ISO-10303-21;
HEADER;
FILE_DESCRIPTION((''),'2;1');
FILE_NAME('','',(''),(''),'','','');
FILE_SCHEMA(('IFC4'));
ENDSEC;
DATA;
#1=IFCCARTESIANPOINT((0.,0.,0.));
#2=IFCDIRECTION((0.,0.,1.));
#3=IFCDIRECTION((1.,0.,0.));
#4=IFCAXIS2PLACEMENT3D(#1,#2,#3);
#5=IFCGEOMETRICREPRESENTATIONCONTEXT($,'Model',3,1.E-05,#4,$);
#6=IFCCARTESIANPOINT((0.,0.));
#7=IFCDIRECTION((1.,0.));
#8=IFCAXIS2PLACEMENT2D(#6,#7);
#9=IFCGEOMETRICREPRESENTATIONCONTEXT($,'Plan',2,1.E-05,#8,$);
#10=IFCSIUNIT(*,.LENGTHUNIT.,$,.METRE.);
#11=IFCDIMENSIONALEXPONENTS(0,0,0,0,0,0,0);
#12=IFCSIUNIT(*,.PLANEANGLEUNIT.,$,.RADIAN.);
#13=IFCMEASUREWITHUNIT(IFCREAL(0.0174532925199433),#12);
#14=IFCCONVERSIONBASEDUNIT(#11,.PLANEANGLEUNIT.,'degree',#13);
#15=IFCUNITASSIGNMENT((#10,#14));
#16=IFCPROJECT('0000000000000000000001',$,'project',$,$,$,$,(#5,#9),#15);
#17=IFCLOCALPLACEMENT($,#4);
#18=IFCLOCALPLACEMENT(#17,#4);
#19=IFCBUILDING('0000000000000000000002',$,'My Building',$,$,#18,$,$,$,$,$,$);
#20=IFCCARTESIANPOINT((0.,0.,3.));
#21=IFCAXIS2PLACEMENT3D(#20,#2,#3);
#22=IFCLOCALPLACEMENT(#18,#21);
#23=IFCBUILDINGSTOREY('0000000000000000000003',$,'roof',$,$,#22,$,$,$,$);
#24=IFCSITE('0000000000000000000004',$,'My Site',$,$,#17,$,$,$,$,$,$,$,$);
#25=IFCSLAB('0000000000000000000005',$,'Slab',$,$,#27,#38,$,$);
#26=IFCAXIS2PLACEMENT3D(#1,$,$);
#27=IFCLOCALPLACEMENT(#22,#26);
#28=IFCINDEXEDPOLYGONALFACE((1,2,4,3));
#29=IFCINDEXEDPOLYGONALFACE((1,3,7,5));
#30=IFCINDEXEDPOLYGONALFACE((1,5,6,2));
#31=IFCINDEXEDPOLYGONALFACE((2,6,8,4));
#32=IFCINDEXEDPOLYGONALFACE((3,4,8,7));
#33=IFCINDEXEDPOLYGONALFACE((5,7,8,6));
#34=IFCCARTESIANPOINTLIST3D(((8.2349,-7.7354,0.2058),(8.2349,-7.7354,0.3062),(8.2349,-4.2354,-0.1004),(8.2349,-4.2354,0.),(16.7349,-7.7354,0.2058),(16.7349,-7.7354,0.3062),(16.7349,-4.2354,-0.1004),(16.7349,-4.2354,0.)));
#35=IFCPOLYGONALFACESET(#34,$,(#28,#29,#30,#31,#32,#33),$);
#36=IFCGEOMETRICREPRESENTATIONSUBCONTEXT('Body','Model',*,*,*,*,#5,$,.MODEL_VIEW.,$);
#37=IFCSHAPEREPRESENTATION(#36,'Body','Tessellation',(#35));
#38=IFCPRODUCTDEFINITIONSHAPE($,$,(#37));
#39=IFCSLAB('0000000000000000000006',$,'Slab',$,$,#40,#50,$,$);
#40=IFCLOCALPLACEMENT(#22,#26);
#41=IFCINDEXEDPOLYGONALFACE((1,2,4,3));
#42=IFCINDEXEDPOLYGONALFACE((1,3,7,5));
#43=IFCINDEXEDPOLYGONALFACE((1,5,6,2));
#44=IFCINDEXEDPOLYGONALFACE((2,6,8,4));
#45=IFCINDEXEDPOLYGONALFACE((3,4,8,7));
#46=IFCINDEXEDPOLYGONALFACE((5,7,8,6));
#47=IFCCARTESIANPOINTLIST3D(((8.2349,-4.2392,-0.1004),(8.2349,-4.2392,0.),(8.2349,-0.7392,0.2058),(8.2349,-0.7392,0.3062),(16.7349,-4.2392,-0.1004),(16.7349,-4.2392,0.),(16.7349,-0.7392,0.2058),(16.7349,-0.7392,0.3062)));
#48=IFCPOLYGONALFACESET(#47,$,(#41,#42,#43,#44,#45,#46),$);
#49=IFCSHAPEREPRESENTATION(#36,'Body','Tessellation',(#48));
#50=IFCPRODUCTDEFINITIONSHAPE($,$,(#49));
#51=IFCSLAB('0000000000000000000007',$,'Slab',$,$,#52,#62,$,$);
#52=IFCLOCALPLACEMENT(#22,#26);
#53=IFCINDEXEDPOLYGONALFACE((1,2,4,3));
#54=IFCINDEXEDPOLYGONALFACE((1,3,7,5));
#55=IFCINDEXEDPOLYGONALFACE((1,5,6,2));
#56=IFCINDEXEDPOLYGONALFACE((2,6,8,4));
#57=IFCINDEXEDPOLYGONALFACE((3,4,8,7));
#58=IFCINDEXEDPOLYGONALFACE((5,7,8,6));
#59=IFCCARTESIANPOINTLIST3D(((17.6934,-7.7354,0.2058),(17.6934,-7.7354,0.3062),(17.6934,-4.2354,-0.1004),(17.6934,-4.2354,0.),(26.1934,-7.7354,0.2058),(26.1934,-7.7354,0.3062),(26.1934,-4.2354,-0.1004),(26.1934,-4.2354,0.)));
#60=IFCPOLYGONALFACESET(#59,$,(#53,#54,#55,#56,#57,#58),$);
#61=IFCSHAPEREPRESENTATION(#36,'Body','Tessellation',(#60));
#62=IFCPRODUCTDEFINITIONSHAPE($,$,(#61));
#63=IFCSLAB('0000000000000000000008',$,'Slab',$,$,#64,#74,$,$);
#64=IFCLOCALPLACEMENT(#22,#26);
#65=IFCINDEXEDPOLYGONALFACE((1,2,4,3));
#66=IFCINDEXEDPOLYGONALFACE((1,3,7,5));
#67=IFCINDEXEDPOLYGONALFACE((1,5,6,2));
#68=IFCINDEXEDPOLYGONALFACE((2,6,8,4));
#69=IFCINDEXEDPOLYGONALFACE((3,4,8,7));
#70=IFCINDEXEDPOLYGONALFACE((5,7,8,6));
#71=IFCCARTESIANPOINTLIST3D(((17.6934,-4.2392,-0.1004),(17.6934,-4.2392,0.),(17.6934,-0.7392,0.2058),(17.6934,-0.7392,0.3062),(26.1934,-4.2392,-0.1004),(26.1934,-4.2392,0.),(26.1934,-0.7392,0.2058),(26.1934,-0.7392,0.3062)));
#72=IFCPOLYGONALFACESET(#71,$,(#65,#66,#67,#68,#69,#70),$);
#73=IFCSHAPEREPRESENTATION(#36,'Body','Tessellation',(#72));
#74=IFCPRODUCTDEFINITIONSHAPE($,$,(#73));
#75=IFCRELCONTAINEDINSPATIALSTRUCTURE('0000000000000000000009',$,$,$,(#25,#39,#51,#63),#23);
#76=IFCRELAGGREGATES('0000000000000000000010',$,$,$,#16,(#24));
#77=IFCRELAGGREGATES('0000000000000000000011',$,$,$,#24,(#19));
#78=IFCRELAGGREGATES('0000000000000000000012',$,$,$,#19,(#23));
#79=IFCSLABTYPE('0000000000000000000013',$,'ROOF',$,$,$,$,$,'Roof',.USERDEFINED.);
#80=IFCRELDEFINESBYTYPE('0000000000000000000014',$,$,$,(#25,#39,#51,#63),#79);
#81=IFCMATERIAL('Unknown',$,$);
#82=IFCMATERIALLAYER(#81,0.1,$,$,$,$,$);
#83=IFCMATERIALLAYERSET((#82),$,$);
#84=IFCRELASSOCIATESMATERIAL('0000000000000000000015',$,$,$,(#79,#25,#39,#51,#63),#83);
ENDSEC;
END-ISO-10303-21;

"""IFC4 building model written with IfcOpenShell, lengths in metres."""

from ifc_helpers import new_model, entity, si_unit, converted_unit, frame, origin_with_axes, origin_2d_with_axis, place, context, subcontext, project, spatial, indexed_curve, outline, extrude, material, layer, layer_set, layer_usage, type_object, element, save


model = new_model("IFC4")

# Units and contexts
model_context = context("Model", 3, precision=1e-05, world=origin_with_axes())
plan_context = context("Plan", 2, precision=1e-05, world=origin_2d_with_axis())
body_context = subcontext(model_context, "Body", "Model", "MODEL_VIEW")
ifc_project = project(units=[si_unit("LENGTHUNIT", "METRE"), converted_unit("PLANEANGLEUNIT", "degree", entity("IfcReal", 0.0174532925199433), si_unit("PLANEANGLEUNIT", "RADIAN"), dimensions=[0, 0, 0, 0, 0, 0, 0])], contexts=[model_context, plan_context])

# Site, building, storey
site_placement = place(None, origin_with_axes())
site = spatial("IfcSite", under=ifc_project, at=site_placement, Name="My Site")
building_placement = place(site_placement, origin_with_axes())
building = spatial("IfcBuilding", under=site, at=building_placement, Name="My Building")
storey_placement = place(building_placement, frame((0.0, 0.0, 3.0), z_axis=(0.0, 0.0, 1.0), x_axis=(1.0, 0.0, 0.0)))
storey = spatial("IfcBuildingStorey", under=building, at=storey_placement, Name="roof")

# Slabs
ifc_material = material(Name="Unknown")
ifc_layer = layer(ifc_material, 0.1)
ifc_layer_set = layer_set([ifc_layer])
ifc_layer_usage_1 = layer_usage(ifc_layer_set, "AXIS3", "POSITIVE", -0.1)
slab_type = type_object("IfcSlabType", Name="ROOF", ElementType="Roof", PredefinedType="USERDEFINED", material=ifc_layer_set)
slab_1_placement = place(storey_placement, frame((8.2349, -4.2354, 0.0), z_axis=(0.0, 0.087156, 0.996195), x_axis=(1.0, 0.0, 0.0)))
element("IfcSlab", 1, at=slab_1_placement, inside=storey, type_object=slab_type, material=ifc_layer_usage_1, Name="Slab", context=body_context, shape_type="SweptSolid", body=[
    extrude(outline(indexed_curve([(0.0, 0.0), (0.0, -3.5134), (8.5, -3.5134), (8.5, 0.0), (0.0, 0.0)])), frame((0.0, 0.0087, -0.1), z_axis=(0.0, 0.0, 1.0), x_axis=(1.0, 0.0, 0.0)), (0.0, -0.087156, 0.996195), 0.1004),
])
ifc_layer_usage_2 = layer_usage(ifc_layer_set, "AXIS3", "POSITIVE", -0.1)
slab_2_placement = place(storey_placement, frame((16.7349, -4.2392, 0.0), z_axis=(0.0, -0.087156, 0.996195), x_axis=(-1.0, 0.0, 0.0)))
element("IfcSlab", 2, at=slab_2_placement, inside=storey, type_object=slab_type, material=ifc_layer_usage_2, Name="Slab", context=body_context, shape_type="SweptSolid", body=[
    extrude(outline(indexed_curve([(0.0, 0.0), (0.0, -3.5134), (8.5, -3.5134), (8.5, 0.0), (0.0, 0.0)])), frame((0.0, 0.0087, -0.1), z_axis=(0.0, 0.0, 1.0), x_axis=(1.0, 0.0, 0.0)), (0.0, -0.087156, 0.996195), 0.1004),
])
ifc_layer_usage_3 = layer_usage(ifc_layer_set, "AXIS3", "POSITIVE", -0.1)
slab_3_placement = place(storey_placement, frame((17.6934, -4.2354, 0.0), z_axis=(0.0, 0.087156, 0.996195), x_axis=(1.0, 0.0, 0.0)))
element("IfcSlab", 3, at=slab_3_placement, inside=storey, type_object=slab_type, material=ifc_layer_usage_3, Name="Slab", context=body_context, shape_type="SweptSolid", body=[
    extrude(outline(indexed_curve([(0.0, 0.0), (0.0, -3.5134), (8.5, -3.5134), (8.5, 0.0), (0.0, 0.0)])), frame((0.0, 0.0087, -0.1), z_axis=(0.0, 0.0, 1.0), x_axis=(1.0, 0.0, 0.0)), (0.0, -0.087156, 0.996195), 0.1004),
])
ifc_layer_usage_4 = layer_usage(ifc_layer_set, "AXIS3", "POSITIVE", -0.1)
slab_4_placement = place(storey_placement, frame((26.1934, -4.2392, 0.0), z_axis=(0.0, -0.087156, 0.996195), x_axis=(-1.0, 0.0, 0.0)))
element("IfcSlab", 4, at=slab_4_placement, inside=storey, type_object=slab_type, material=ifc_layer_usage_4, Name="Slab", context=body_context, shape_type="SweptSolid", body=[
    extrude(outline(indexed_curve([(0.0, 0.0), (0.0, -3.5134), (8.5, -3.5134), (8.5, 0.0), (0.0, 0.0)])), frame((0.0, 0.0087, -0.1), z_axis=(0.0, 0.0, 1.0), x_axis=(1.0, 0.0, 0.0)), (0.0, -0.087156, 0.996195), 0.1004),
])

save(model, "model.ifc")
